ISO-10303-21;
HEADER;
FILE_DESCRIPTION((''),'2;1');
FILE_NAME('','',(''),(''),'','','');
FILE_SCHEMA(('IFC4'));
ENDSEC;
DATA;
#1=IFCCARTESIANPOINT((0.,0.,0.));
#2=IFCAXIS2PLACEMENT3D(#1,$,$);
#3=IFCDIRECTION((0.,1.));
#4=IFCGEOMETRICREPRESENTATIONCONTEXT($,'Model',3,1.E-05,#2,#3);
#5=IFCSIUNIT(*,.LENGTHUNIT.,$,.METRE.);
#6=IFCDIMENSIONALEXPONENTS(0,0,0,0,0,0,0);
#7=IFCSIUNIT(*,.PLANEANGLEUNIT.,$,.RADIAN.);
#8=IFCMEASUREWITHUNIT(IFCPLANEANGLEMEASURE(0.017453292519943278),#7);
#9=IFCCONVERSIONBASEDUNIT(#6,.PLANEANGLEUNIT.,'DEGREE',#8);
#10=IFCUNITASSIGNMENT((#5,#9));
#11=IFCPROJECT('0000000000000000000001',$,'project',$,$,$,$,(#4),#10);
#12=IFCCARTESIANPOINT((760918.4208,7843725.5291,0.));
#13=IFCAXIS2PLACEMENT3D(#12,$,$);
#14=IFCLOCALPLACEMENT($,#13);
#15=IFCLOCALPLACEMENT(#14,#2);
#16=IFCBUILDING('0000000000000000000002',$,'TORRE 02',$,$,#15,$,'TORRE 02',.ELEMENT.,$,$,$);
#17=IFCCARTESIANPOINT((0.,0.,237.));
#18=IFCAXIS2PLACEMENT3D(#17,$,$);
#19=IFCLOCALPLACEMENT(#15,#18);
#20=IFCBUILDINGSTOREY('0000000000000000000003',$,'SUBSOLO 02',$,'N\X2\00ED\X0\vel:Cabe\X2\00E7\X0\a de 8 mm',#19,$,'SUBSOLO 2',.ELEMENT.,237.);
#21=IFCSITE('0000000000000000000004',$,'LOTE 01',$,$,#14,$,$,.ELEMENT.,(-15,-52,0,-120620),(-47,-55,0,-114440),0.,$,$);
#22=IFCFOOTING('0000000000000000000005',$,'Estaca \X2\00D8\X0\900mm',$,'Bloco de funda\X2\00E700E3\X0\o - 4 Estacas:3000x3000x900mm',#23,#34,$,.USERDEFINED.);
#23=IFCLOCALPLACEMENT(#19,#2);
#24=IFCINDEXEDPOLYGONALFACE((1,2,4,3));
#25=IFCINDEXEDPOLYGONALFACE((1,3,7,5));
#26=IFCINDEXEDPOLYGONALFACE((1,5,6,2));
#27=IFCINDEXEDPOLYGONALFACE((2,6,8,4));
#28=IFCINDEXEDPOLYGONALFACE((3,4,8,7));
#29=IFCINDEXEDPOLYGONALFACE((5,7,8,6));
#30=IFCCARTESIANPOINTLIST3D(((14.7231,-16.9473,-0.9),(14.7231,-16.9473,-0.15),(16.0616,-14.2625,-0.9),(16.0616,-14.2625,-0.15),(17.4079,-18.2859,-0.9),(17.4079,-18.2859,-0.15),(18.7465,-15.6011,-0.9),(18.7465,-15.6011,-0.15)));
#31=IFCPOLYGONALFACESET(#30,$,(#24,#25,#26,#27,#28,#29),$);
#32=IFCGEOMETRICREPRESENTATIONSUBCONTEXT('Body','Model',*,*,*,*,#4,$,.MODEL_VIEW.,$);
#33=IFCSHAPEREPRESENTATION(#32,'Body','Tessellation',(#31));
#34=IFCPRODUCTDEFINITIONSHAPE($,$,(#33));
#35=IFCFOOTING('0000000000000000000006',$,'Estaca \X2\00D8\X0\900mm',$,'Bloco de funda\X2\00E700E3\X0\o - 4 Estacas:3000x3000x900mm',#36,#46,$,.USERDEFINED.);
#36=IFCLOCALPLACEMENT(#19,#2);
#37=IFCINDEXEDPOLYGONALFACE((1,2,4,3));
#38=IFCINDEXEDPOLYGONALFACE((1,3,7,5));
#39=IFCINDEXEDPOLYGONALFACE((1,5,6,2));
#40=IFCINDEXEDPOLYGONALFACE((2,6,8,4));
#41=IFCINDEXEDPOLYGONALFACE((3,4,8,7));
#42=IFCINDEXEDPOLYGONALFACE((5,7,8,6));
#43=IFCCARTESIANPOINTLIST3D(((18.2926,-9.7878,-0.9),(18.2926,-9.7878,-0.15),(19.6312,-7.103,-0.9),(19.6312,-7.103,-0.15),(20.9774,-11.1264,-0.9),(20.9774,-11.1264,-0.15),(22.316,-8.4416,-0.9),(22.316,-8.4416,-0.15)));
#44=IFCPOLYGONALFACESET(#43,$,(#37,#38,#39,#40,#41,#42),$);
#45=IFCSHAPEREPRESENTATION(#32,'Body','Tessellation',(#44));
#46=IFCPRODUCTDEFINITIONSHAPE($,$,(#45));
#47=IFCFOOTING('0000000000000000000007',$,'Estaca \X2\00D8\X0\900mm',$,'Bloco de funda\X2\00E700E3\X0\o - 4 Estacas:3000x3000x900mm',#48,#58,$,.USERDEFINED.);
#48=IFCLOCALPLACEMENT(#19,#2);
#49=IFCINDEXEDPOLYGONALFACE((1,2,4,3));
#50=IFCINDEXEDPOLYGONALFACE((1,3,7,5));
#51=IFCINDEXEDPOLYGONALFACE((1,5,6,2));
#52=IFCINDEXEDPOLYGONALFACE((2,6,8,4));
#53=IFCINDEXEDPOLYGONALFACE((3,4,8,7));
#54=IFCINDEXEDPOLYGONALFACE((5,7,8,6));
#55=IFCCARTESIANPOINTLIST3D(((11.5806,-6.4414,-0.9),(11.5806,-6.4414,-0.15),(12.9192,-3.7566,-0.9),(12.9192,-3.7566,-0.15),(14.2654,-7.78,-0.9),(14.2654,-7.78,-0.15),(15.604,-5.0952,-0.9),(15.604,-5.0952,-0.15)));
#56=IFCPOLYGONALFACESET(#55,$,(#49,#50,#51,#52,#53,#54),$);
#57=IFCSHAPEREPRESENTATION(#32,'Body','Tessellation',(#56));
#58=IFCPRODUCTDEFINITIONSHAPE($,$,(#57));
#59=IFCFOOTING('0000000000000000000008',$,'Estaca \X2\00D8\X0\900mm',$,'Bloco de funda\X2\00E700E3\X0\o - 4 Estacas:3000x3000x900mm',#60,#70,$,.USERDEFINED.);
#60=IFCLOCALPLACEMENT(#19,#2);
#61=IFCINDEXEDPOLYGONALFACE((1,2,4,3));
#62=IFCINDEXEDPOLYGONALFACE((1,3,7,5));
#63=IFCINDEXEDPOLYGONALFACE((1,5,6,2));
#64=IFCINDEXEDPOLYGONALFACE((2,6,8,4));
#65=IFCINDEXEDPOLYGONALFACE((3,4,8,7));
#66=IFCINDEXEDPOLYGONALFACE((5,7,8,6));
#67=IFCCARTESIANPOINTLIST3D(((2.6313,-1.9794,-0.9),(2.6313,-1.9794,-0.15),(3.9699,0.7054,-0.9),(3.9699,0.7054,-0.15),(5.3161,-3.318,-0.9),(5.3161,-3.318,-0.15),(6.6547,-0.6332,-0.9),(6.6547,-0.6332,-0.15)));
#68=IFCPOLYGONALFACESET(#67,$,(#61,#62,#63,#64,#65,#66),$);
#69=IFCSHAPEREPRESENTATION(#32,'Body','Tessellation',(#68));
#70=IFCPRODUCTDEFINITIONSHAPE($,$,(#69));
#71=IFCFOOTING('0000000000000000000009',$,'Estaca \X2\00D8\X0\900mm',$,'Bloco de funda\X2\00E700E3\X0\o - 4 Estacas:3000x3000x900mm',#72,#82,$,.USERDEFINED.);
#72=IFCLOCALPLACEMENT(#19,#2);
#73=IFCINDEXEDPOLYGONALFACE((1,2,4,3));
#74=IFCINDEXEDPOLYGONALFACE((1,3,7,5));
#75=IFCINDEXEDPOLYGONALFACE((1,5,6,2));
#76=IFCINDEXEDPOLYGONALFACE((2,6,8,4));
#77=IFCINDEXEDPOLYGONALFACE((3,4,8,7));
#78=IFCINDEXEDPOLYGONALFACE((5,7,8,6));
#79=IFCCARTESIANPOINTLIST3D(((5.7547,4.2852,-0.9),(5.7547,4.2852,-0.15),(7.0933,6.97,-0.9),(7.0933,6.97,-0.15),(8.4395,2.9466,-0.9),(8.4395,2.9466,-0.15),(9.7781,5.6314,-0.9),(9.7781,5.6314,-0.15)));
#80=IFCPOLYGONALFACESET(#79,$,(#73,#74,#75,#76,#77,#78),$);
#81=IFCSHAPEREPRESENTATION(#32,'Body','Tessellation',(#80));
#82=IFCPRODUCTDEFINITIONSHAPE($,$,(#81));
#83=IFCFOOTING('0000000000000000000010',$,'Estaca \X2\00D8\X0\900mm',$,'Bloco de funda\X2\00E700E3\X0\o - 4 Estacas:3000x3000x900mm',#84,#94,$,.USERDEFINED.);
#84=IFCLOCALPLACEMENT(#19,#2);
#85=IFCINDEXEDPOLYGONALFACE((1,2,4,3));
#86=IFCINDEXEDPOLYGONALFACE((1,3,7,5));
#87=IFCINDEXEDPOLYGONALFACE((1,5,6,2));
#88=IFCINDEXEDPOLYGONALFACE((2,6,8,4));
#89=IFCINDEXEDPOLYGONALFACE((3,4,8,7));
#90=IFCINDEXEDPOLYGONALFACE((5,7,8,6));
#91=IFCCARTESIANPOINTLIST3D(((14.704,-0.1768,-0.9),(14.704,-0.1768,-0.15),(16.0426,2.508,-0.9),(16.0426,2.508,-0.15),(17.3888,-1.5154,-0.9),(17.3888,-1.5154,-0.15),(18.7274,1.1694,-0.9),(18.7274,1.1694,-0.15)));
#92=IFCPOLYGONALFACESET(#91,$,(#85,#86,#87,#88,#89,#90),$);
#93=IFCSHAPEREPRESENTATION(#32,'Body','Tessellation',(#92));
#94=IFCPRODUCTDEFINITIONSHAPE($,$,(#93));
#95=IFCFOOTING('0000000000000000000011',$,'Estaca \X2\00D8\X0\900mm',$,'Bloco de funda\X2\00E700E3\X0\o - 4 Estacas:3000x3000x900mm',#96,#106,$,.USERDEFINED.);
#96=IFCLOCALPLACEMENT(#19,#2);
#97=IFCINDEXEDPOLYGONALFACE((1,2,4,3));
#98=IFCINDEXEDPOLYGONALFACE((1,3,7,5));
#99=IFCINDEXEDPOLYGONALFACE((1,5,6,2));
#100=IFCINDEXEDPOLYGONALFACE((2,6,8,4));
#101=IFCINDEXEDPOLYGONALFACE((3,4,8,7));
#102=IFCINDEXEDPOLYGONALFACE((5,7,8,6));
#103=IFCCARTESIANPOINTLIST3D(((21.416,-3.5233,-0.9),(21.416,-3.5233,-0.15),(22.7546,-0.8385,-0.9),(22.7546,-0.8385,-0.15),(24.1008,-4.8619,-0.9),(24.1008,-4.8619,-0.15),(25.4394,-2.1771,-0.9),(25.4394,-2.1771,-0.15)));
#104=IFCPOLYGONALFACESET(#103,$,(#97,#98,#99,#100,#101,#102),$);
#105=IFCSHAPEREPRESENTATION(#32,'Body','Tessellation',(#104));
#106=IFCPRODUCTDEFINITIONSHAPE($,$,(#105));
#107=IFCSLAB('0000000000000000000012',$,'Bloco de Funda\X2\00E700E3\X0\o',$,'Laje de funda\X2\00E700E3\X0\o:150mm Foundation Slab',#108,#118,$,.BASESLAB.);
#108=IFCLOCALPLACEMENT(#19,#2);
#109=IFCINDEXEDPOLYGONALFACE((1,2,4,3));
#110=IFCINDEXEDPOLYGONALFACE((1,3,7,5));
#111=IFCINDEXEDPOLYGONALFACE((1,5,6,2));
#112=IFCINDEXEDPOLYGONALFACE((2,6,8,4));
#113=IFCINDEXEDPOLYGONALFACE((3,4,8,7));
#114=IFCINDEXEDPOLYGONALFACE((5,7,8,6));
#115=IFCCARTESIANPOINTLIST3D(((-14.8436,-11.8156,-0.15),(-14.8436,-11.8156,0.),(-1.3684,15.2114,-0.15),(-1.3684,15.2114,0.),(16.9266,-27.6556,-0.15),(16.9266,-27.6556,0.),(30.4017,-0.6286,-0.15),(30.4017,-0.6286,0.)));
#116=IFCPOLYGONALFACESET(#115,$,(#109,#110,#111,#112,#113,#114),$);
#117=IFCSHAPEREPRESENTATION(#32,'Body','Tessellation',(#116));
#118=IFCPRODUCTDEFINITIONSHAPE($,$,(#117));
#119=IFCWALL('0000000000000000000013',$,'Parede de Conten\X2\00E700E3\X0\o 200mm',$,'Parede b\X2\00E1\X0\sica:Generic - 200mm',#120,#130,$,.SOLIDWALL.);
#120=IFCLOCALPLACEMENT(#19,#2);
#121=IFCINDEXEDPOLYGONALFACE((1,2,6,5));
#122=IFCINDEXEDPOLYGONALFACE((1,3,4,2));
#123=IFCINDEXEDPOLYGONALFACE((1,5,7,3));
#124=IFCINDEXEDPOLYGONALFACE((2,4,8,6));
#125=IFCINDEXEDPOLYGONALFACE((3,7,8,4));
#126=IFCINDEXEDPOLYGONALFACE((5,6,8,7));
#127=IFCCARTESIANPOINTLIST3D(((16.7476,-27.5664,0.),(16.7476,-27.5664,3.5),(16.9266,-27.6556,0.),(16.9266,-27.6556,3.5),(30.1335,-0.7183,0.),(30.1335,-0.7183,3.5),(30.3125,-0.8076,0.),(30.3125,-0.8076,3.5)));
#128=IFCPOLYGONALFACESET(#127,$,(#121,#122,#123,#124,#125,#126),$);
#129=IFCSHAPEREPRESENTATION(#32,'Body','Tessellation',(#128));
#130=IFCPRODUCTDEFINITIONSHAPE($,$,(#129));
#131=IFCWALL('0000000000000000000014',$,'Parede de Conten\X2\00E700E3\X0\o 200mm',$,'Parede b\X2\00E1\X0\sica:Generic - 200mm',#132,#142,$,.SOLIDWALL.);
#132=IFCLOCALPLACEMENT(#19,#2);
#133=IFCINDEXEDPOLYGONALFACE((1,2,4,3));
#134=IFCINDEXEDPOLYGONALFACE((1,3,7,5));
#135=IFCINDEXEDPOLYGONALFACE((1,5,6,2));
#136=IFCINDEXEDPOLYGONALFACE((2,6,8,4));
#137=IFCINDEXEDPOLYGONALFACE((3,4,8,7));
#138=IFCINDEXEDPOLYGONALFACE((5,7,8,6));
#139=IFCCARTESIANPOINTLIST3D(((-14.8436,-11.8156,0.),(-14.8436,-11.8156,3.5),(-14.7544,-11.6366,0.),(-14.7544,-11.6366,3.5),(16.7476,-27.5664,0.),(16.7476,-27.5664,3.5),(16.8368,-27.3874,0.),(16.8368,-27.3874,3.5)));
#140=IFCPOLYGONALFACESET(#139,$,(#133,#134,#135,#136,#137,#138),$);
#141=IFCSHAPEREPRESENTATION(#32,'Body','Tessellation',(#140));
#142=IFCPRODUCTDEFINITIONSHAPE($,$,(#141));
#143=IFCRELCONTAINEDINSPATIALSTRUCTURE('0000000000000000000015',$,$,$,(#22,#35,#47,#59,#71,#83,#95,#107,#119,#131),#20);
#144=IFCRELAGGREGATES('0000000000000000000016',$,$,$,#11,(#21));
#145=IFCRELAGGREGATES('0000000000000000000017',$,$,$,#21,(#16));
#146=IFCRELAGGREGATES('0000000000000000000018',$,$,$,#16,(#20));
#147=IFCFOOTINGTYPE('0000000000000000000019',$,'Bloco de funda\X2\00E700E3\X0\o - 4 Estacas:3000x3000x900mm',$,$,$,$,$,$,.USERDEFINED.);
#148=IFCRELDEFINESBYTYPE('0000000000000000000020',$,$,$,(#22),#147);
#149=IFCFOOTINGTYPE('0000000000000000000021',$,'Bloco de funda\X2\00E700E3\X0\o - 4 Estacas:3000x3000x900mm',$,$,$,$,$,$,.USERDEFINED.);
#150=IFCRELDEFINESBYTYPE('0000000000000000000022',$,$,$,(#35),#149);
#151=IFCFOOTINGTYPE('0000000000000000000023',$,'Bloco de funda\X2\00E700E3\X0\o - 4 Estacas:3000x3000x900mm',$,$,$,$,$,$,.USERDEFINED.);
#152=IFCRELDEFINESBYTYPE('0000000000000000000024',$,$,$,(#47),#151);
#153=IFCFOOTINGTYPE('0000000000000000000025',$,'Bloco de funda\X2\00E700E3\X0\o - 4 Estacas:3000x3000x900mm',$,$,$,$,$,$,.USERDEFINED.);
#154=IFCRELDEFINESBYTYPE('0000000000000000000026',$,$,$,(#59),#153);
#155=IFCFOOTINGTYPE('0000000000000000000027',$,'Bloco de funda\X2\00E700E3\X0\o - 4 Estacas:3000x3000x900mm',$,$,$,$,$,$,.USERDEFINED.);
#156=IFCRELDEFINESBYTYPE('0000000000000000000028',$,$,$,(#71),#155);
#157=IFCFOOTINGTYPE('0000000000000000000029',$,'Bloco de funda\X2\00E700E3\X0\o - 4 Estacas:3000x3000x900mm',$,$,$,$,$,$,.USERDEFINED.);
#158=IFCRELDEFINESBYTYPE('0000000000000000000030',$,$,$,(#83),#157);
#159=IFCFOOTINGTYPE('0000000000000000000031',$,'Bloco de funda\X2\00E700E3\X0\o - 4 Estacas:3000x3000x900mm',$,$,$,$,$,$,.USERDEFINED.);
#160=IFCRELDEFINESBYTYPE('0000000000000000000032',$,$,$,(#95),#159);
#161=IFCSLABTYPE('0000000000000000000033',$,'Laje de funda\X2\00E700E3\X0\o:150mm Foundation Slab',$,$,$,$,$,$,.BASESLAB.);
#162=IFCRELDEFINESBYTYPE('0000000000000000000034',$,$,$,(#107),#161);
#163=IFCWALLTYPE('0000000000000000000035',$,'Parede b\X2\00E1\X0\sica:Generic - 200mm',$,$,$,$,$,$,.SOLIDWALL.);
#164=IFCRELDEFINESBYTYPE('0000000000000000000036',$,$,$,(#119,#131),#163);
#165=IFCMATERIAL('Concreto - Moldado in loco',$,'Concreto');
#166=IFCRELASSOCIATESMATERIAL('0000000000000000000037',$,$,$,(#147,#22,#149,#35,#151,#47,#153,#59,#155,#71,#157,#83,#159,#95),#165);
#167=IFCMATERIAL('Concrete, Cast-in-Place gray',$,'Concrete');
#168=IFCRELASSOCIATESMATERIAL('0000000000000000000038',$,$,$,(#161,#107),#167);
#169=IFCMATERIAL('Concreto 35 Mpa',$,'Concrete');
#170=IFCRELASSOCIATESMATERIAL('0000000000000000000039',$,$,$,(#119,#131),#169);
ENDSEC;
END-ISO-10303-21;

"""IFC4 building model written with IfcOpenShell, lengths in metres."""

from ifc_helpers import new_model, entity, si_unit, converted_unit, direction, frame, origin, place, context, subcontext, project, spatial, indexed_curve, outline, extrude, source, transform, mapped, material, type_object, type_shapes, element, save


model = new_model("IFC4")

# Units and contexts
model_context = context("Model", 3, precision=1e-05, world=origin(), true_north=direction((0.0, 1.0)))
body_context = subcontext(model_context, "Body", "Model", "MODEL_VIEW")
ifc_project = project(units=[si_unit("LENGTHUNIT", "METRE"), converted_unit("PLANEANGLEUNIT", "DEGREE", entity("IfcPlaneAngleMeasure", 0.017453292519943278), si_unit("PLANEANGLEUNIT", "RADIAN"), dimensions=[0, 0, 0, 0, 0, 0, 0])], contexts=[model_context])

# Site, building, storey
site_placement = place(None, frame((760918.4208, 7843725.5291, 0.0)))
site = spatial("IfcSite", under=ifc_project, at=site_placement, Name="LOTE 01", CompositionType="ELEMENT", RefLatitude=(-15, -52, 0, -120620), RefLongitude=(-47, -55, 0, -114440), RefElevation=0.0)
building_placement = place(site_placement, origin())
building = spatial("IfcBuilding", under=site, at=building_placement, Name="TORRE 02", LongName="TORRE 02", CompositionType="ELEMENT")
storey_placement = place(building_placement, frame((0.0, 0.0, 237.0)))
storey = spatial("IfcBuildingStorey", under=building, at=storey_placement, Name="SUBSOLO 02", ObjectType="Nível:Cabeça de 8 mm", LongName="SUBSOLO 2", CompositionType="ELEMENT", Elevation=237.0)

# Footings
ifc_material_1 = material(Name="Concreto - Moldado in loco", Category="Concreto")
placement = place(building_placement, frame((0.0, 0.0, 237.0)))
footing_type_1 = type_object("IfcFootingType", Name="Bloco de fundação - 4 Estacas:3000x3000x900mm", PredefinedType="USERDEFINED", material=ifc_material_1)
shared_shape_1 = source(origin(), body_context, "Body", "SweptSolid", [
    extrude(outline(indexed_curve([(-1.5, -1.5), (1.5, -1.5), (1.5, 1.5), (-1.5, 1.5), (-1.5, -1.5)], self_intersect=False)), frame((16.7348, -16.2742, -0.9), z_axis=(0.0, 0.0, 1.0), x_axis=(-0.894934, 0.446198, 0.0)), (0.0, 0.0, 1.0), 0.75),
])
type_shapes(footing_type_1, [shared_shape_1])
footing_1_placement = place(placement, origin())
element("IfcFooting", 1, at=footing_1_placement, inside=storey, type_object=footing_type_1, material=ifc_material_1, Name="Estaca Ø900mm", ObjectType="Bloco de fundação - 4 Estacas:3000x3000x900mm", PredefinedType="USERDEFINED", context=body_context, shape_type="MappedRepresentation", body=[
    mapped(shared_shape_1, transform((0.0, 0.0, 0.0), scale=1.0)),
])
footing_type_2 = type_object("IfcFootingType", Name="Bloco de fundação - 4 Estacas:3000x3000x900mm", PredefinedType="USERDEFINED", material=ifc_material_1)
shared_shape_2 = source(origin(), body_context, "Body", "SweptSolid", [
    extrude(outline(indexed_curve([(-1.5, -1.5), (1.5, -1.5), (1.5, 1.5), (-1.5, 1.5), (-1.5, -1.5)], self_intersect=False)), frame((20.3043, -9.1147, -0.9), z_axis=(0.0, 0.0, 1.0), x_axis=(-0.894934, 0.446198, 0.0)), (0.0, 0.0, 1.0), 0.75),
])
type_shapes(footing_type_2, [shared_shape_2])
footing_2_placement = place(placement, origin())
element("IfcFooting", 2, at=footing_2_placement, inside=storey, type_object=footing_type_2, material=ifc_material_1, Name="Estaca Ø900mm", ObjectType="Bloco de fundação - 4 Estacas:3000x3000x900mm", PredefinedType="USERDEFINED", context=body_context, shape_type="MappedRepresentation", body=[
    mapped(shared_shape_2, transform((0.0, 0.0, 0.0), scale=1.0)),
])
footing_type_3 = type_object("IfcFootingType", Name="Bloco de fundação - 4 Estacas:3000x3000x900mm", PredefinedType="USERDEFINED", material=ifc_material_1)
shared_shape_3 = source(origin(), body_context, "Body", "SweptSolid", [
    extrude(outline(indexed_curve([(-1.5, -1.5), (1.5, -1.5), (1.5, 1.5), (-1.5, 1.5), (-1.5, -1.5)], self_intersect=False)), frame((13.5923, -5.7683, -0.9), z_axis=(0.0, 0.0, 1.0), x_axis=(-0.894934, 0.446198, 0.0)), (0.0, 0.0, 1.0), 0.75),
])
type_shapes(footing_type_3, [shared_shape_3])
footing_3_placement = place(placement, origin())
element("IfcFooting", 3, at=footing_3_placement, inside=storey, type_object=footing_type_3, material=ifc_material_1, Name="Estaca Ø900mm", ObjectType="Bloco de fundação - 4 Estacas:3000x3000x900mm", PredefinedType="USERDEFINED", context=body_context, shape_type="MappedRepresentation", body=[
    mapped(shared_shape_3, transform((0.0, 0.0, 0.0), scale=1.0)),
])
footing_type_4 = type_object("IfcFootingType", Name="Bloco de fundação - 4 Estacas:3000x3000x900mm", PredefinedType="USERDEFINED", material=ifc_material_1)
shared_shape_4 = source(origin(), body_context, "Body", "SweptSolid", [
    extrude(outline(indexed_curve([(-1.5, -1.5), (1.5, -1.5), (1.5, 1.5), (-1.5, 1.5), (-1.5, -1.5)], self_intersect=False)), frame((4.643, -1.3063, -0.9), z_axis=(0.0, 0.0, 1.0), x_axis=(-0.894934, 0.446198, 0.0)), (0.0, 0.0, 1.0), 0.75),
])
type_shapes(footing_type_4, [shared_shape_4])
footing_4_placement = place(placement, origin())
element("IfcFooting", 4, at=footing_4_placement, inside=storey, type_object=footing_type_4, material=ifc_material_1, Name="Estaca Ø900mm", ObjectType="Bloco de fundação - 4 Estacas:3000x3000x900mm", PredefinedType="USERDEFINED", context=body_context, shape_type="MappedRepresentation", body=[
    mapped(shared_shape_4, transform((0.0, 0.0, 0.0), scale=1.0)),
])
footing_type_5 = type_object("IfcFootingType", Name="Bloco de fundação - 4 Estacas:3000x3000x900mm", PredefinedType="USERDEFINED", material=ifc_material_1)
shared_shape_5 = source(origin(), body_context, "Body", "SweptSolid", [
    extrude(outline(indexed_curve([(-1.5, -1.5), (1.5, -1.5), (1.5, 1.5), (-1.5, 1.5), (-1.5, -1.5)], self_intersect=False)), frame((7.7664, 4.9583, -0.9), z_axis=(0.0, 0.0, 1.0), x_axis=(-0.894934, 0.446198, 0.0)), (0.0, 0.0, 1.0), 0.75),
])
type_shapes(footing_type_5, [shared_shape_5])
footing_5_placement = place(placement, origin())
element("IfcFooting", 5, at=footing_5_placement, inside=storey, type_object=footing_type_5, material=ifc_material_1, Name="Estaca Ø900mm", ObjectType="Bloco de fundação - 4 Estacas:3000x3000x900mm", PredefinedType="USERDEFINED", context=body_context, shape_type="MappedRepresentation", body=[
    mapped(shared_shape_5, transform((0.0, 0.0, 0.0), scale=1.0)),
])
footing_type_6 = type_object("IfcFootingType", Name="Bloco de fundação - 4 Estacas:3000x3000x900mm", PredefinedType="USERDEFINED", material=ifc_material_1)
shared_shape_6 = source(origin(), body_context, "Body", "SweptSolid", [
    extrude(outline(indexed_curve([(-1.5, -1.5), (1.5, -1.5), (1.5, 1.5), (-1.5, 1.5), (-1.5, -1.5)], self_intersect=False)), frame((16.7157, 0.4963, -0.9), z_axis=(0.0, 0.0, 1.0), x_axis=(-0.894934, 0.446198, 0.0)), (0.0, 0.0, 1.0), 0.75),
])
type_shapes(footing_type_6, [shared_shape_6])
footing_6_placement = place(placement, origin())
element("IfcFooting", 6, at=footing_6_placement, inside=storey, type_object=footing_type_6, material=ifc_material_1, Name="Estaca Ø900mm", ObjectType="Bloco de fundação - 4 Estacas:3000x3000x900mm", PredefinedType="USERDEFINED", context=body_context, shape_type="MappedRepresentation", body=[
    mapped(shared_shape_6, transform((0.0, 0.0, 0.0), scale=1.0)),
])
footing_type_7 = type_object("IfcFootingType", Name="Bloco de fundação - 4 Estacas:3000x3000x900mm", PredefinedType="USERDEFINED", material=ifc_material_1)
shared_shape_7 = source(origin(), body_context, "Body", "SweptSolid", [
    extrude(outline(indexed_curve([(-1.5, -1.5), (1.5, -1.5), (1.5, 1.5), (-1.5, 1.5), (-1.5, -1.5)], self_intersect=False)), frame((23.4277, -2.8502, -0.9), z_axis=(0.0, 0.0, 1.0), x_axis=(-0.894934, 0.446198, 0.0)), (0.0, 0.0, 1.0), 0.75),
])
type_shapes(footing_type_7, [shared_shape_7])
footing_7_placement = place(placement, origin())
element("IfcFooting", 7, at=footing_7_placement, inside=storey, type_object=footing_type_7, material=ifc_material_1, Name="Estaca Ø900mm", ObjectType="Bloco de fundação - 4 Estacas:3000x3000x900mm", PredefinedType="USERDEFINED", context=body_context, shape_type="MappedRepresentation", body=[
    mapped(shared_shape_7, transform((0.0, 0.0, 0.0), scale=1.0)),
])

# Slab
ifc_material_2 = material(Name="Concrete, Cast-in-Place gray", Category="Concrete")
slab_type = type_object("IfcSlabType", Name="Laje de fundação:150mm Foundation Slab", PredefinedType="BASESLAB", material=ifc_material_2)
slab_placement = place(placement, origin())
element("IfcSlab", 8, at=slab_placement, inside=storey, type_object=slab_type, material=ifc_material_2, Name="Bloco de Fundação", ObjectType="Laje de fundação:150mm Foundation Slab", PredefinedType="BASESLAB", context=body_context, shape_type="SweptSolid", body=[
    extrude(outline(indexed_curve([(-15.1, -17.75), (15.1, -17.75), (15.1, 17.75), (-15.1, 17.75), (-15.1, -17.75)], self_intersect=False)), frame((7.7791, -6.2221, 0.0), z_axis=(0.0, 0.0, -1.0), x_axis=(-0.446198, -0.894934, 0.0)), (0.0, 0.0, 1.0), 0.15),
])

# Walls
ifc_material_3 = material(Name="Concreto 35 Mpa", Category="Concrete")
wall_type = type_object("IfcWallType", Name="Parede básica:Generic - 200mm", PredefinedType="SOLIDWALL")
wall_1_placement = place(placement, frame((30.223, -0.7629, 0.0), z_axis=(0.0, 0.0, 1.0), x_axis=(-0.446198, -0.894934, 0.0)))
element("IfcWall", 9, at=wall_1_placement, inside=storey, type_object=wall_type, material=ifc_material_3, Name="Parede de Contenção 200mm", ObjectType="Parede básica:Generic - 200mm", PredefinedType="SOLIDWALL", context=body_context, shape_type="SweptSolid", body=[
    extrude(outline(indexed_curve([(30.0, 0.1), (0.0, 0.1), (0.0, -0.1), (30.0, -0.1), (30.0, 0.1)], self_intersect=False)), origin(), (0.0, 0.0, 1.0), 3.5),
])
wall_2_placement = place(placement, frame((16.7922, -27.4769, 0.0), z_axis=(0.0, 0.0, 1.0), x_axis=(-0.894934, 0.446198, 0.0)))
element("IfcWall", 10, at=wall_2_placement, inside=storey, type_object=wall_type, material=ifc_material_3, Name="Parede de Contenção 200mm", ObjectType="Parede básica:Generic - 200mm", PredefinedType="SOLIDWALL", context=body_context, shape_type="SweptSolid", body=[
    extrude(outline(indexed_curve([(35.3, 0.1), (0.0, 0.1), (0.0, -0.1), (35.3, -0.1), (35.3, 0.1)], self_intersect=False)), origin(), (0.0, 0.0, 1.0), 3.5),
])

save(model, "model.ifc")
